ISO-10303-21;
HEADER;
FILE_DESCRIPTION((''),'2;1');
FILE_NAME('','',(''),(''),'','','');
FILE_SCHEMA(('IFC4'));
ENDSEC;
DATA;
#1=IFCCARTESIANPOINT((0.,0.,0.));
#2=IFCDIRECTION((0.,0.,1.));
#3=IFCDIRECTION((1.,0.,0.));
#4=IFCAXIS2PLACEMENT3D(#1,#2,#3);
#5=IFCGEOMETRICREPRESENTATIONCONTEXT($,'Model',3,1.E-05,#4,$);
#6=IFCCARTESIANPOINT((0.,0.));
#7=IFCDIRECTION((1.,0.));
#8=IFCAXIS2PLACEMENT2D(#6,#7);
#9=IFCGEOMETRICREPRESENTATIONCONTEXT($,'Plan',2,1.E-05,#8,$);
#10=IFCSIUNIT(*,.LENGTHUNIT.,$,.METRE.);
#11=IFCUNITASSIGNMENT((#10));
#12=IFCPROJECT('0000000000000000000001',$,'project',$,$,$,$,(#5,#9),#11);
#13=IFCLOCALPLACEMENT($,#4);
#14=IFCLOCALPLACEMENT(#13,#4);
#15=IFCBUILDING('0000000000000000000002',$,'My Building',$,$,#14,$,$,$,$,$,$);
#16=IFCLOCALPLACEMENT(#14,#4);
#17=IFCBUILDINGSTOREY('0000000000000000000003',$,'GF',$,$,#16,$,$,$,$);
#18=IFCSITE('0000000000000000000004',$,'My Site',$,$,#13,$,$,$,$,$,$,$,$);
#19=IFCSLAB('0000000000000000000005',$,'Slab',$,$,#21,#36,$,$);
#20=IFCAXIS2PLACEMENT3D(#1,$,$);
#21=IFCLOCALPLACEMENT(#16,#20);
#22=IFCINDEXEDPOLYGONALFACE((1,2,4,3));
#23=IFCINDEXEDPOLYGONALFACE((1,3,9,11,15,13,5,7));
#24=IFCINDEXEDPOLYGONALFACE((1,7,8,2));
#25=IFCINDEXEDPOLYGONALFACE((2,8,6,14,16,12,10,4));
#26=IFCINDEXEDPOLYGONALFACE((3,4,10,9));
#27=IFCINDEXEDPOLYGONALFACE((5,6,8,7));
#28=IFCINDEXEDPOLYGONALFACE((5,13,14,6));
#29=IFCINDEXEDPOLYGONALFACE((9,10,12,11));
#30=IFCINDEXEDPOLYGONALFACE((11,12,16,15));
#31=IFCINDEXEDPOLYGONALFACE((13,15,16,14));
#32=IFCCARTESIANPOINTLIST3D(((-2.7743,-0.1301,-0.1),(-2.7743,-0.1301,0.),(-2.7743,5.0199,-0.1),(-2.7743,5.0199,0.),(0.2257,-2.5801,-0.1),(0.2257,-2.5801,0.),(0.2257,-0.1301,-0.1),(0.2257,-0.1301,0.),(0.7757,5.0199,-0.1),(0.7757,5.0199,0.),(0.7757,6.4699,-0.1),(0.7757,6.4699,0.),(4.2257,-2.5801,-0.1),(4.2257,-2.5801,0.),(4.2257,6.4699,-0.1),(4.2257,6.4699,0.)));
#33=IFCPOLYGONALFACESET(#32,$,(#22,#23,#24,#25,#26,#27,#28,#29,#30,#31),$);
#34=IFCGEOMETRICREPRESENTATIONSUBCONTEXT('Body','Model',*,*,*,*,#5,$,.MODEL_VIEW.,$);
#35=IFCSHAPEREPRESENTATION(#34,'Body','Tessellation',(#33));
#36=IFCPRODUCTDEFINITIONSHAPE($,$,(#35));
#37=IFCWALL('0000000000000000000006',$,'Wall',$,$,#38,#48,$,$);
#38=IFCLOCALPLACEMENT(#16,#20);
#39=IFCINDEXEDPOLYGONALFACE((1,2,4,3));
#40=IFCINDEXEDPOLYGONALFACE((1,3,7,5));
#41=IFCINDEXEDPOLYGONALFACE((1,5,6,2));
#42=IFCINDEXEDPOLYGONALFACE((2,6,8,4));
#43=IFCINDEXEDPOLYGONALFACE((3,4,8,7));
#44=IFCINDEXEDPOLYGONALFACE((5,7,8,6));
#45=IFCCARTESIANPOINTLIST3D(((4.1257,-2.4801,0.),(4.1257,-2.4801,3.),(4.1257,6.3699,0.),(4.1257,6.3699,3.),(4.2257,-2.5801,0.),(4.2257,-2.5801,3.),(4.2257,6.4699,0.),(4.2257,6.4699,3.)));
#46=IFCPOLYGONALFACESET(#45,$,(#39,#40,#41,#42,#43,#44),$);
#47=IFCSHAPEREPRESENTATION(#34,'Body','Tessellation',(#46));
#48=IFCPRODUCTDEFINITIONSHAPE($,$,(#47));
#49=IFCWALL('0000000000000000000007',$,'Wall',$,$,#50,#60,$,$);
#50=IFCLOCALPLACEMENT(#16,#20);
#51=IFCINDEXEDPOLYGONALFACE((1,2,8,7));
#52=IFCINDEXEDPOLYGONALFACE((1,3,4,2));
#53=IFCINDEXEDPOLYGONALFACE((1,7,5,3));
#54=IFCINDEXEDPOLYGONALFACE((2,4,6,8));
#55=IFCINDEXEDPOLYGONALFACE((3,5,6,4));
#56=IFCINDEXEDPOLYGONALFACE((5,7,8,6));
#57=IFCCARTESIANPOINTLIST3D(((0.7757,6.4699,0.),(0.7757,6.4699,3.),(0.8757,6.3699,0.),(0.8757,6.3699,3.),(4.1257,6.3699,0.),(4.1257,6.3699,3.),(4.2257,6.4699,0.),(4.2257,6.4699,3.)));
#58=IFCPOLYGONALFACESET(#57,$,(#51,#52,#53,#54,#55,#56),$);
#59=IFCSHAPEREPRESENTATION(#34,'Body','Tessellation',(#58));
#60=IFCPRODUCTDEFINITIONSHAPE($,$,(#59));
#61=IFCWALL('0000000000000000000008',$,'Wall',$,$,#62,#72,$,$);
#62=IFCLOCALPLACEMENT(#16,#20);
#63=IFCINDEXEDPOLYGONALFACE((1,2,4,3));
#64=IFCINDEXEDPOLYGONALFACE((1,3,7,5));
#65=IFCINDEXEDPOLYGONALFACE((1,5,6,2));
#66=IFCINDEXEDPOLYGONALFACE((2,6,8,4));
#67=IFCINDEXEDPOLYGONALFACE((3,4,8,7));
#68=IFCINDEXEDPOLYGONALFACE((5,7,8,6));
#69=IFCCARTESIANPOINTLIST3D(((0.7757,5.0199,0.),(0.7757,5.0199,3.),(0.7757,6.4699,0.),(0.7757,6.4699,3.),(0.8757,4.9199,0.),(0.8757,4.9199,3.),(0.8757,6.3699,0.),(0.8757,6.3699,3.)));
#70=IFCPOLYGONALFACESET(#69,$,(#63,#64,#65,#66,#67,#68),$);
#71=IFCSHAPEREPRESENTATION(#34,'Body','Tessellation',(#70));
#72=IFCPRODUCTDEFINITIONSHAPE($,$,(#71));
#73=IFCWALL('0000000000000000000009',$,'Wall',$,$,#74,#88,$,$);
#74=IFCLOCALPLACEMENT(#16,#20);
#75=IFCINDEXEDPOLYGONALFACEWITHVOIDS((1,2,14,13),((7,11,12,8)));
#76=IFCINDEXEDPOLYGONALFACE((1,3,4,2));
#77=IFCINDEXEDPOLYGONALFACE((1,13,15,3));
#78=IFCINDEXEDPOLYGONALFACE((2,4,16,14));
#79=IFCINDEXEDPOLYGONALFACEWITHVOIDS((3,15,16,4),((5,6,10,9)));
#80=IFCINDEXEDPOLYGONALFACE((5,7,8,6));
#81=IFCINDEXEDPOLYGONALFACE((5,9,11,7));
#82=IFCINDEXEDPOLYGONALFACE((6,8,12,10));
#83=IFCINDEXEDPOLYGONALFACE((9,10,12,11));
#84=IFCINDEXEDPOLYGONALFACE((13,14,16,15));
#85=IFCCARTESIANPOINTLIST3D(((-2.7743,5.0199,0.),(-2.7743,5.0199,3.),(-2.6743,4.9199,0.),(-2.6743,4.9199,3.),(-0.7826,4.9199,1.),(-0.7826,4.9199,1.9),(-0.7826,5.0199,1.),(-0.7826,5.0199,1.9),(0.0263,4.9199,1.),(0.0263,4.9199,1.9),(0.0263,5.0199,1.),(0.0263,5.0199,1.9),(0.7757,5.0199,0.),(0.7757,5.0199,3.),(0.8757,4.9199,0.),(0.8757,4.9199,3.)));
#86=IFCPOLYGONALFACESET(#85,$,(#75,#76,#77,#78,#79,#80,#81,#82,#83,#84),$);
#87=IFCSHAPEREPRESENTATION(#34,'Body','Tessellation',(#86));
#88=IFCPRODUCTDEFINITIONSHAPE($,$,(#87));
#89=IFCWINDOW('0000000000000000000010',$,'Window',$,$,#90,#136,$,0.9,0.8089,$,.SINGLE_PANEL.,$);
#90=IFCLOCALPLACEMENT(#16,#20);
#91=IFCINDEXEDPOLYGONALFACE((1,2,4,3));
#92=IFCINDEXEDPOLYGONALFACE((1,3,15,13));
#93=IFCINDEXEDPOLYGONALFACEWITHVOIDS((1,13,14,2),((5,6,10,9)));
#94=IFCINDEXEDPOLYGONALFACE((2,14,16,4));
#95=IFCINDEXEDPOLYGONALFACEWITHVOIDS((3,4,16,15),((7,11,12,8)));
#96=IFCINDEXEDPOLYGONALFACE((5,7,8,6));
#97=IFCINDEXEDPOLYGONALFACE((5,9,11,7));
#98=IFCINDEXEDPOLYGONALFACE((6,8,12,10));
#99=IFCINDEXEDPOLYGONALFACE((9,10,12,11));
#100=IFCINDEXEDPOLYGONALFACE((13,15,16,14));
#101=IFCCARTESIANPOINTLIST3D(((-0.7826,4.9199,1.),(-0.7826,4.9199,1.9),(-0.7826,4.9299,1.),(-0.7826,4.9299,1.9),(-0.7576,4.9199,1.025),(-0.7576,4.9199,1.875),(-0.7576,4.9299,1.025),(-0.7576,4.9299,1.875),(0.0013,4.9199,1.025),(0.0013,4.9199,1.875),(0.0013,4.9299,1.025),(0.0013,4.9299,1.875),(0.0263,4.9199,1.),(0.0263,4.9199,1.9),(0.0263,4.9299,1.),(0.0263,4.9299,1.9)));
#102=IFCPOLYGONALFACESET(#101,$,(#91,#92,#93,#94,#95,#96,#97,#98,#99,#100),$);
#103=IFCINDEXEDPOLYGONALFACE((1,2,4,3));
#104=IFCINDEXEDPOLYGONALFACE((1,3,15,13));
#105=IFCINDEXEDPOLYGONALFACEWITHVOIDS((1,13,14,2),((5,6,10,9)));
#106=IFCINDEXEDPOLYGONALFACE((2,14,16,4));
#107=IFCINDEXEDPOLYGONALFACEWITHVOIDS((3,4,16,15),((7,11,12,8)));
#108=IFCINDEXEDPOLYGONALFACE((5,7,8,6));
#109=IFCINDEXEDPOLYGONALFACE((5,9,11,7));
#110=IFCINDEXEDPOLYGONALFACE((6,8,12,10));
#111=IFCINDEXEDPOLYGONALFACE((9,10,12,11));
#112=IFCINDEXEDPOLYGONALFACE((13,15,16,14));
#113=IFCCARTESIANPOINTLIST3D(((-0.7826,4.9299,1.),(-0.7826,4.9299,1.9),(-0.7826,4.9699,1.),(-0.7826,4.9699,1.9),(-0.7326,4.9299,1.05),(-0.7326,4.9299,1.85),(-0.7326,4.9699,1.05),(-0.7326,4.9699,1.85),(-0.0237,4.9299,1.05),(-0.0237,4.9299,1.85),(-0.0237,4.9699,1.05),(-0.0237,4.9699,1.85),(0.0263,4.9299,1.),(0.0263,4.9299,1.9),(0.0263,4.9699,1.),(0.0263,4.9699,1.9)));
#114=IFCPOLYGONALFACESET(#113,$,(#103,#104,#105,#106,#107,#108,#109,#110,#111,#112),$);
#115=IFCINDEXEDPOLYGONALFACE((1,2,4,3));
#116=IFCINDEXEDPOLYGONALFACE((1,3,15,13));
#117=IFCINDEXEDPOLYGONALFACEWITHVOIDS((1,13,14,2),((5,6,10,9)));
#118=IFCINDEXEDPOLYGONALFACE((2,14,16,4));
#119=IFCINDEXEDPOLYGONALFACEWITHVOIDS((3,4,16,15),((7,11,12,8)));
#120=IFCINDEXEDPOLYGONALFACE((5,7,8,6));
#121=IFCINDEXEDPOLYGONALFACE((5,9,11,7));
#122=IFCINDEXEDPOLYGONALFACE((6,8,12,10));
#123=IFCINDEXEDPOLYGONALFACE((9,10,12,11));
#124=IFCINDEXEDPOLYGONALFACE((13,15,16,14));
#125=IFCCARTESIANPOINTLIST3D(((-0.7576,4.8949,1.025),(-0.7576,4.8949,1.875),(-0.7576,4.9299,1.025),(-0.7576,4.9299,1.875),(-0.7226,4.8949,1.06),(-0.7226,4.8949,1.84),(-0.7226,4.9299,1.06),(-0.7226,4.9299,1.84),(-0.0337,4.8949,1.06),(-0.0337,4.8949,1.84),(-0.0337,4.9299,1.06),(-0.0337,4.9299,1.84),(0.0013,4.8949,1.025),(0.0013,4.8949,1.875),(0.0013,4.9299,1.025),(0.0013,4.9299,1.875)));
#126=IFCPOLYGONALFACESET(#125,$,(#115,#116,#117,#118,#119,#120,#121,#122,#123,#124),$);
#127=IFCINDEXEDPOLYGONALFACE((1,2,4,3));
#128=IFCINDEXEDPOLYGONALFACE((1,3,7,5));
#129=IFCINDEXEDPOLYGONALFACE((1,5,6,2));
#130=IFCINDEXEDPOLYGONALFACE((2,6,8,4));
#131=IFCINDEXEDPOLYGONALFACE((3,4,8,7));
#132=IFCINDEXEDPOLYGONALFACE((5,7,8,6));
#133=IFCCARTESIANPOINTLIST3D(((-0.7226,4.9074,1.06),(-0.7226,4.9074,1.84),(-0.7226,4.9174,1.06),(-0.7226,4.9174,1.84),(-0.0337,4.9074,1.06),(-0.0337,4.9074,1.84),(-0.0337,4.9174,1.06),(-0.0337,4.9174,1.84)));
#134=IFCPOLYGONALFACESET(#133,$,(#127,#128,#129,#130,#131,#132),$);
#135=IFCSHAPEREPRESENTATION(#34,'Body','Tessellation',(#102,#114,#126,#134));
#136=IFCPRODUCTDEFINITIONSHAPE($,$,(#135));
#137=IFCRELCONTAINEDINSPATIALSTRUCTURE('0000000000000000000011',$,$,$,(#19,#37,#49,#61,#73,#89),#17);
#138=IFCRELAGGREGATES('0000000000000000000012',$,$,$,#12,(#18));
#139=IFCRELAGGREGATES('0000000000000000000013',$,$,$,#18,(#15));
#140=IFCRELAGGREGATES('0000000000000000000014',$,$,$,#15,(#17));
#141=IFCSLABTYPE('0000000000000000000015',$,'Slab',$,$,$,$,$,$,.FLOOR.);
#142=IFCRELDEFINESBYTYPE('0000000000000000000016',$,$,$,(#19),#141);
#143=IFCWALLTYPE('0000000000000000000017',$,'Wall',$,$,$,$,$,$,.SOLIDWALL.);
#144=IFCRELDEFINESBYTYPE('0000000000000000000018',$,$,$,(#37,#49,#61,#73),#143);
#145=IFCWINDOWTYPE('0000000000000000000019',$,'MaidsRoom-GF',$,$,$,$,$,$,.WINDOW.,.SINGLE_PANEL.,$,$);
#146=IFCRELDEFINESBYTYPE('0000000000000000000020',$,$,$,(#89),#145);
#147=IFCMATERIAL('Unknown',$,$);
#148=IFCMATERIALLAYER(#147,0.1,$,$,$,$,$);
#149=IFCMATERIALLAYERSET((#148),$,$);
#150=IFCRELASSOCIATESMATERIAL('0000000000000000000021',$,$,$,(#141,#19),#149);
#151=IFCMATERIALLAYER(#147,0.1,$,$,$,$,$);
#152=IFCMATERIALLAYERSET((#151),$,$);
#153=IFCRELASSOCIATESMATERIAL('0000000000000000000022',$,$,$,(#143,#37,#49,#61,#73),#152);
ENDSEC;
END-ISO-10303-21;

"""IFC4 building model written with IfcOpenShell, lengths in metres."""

from ifc_helpers import new_model, entity, si_unit, frame, origin_with_axes, origin_2d_with_axis, place, context, subcontext, project, spatial, line, indexed_curve, outline, extrude, shape, source, transform, mapped, material, layer, layer_set, layer_usage, type_object, type_shapes, element, fill, save


model = new_model("IFC4")

# Units and contexts
model_context = context("Model", 3, precision=1e-05, world=origin_with_axes())
plan_context = context("Plan", 2, precision=1e-05, world=origin_2d_with_axis())
body_context_1 = subcontext(model_context, "Body", "Model", "MODEL_VIEW")
body_context_2 = subcontext(plan_context, "Body", "Plan", "PLAN_VIEW")
ifc_project = project(units=[si_unit("LENGTHUNIT", "METRE")], contexts=[model_context, plan_context])

# Site, building, storey
site_placement = place(None, origin_with_axes())
site = spatial("IfcSite", under=ifc_project, at=site_placement, Name="My Site")
building_placement = place(site_placement, origin_with_axes())
building = spatial("IfcBuilding", under=site, at=building_placement, Name="My Building")
storey_placement = place(building_placement, origin_with_axes())
storey = spatial("IfcBuildingStorey", under=building, at=storey_placement, Name="GF")

# Slab
ifc_material = material(Name="Unknown")
ifc_layer_1 = layer(ifc_material, 0.1)
ifc_layer_set_1 = layer_set([ifc_layer_1])
ifc_layer_usage_1 = layer_usage(ifc_layer_set_1, "AXIS3", "POSITIVE", -0.1)
slab_type = type_object("IfcSlabType", Name="Slab", PredefinedType="FLOOR", material=ifc_layer_set_1)
slab_placement = place(storey_placement, frame((4.2257, 6.4699, 0.0), z_axis=(0.0, 0.0, 1.0), x_axis=(1.0, 0.0, 0.0)))
element("IfcSlab", 1, at=slab_placement, inside=storey, type_object=slab_type, material=ifc_layer_usage_1, Name="Slab", context=body_context_1, shape_type="SweptSolid", body=[
    extrude(outline(indexed_curve([(0.0, 0.0), (-3.45, 0.0), (-3.45, -1.45), (-7.0, -1.45), (-7.0, -6.6), (-4.0, -6.6), (-4.0, -9.05), (0.0, -9.05), (0.0, 0.0)])), frame((0.0, 0.0, -0.1), z_axis=(0.0, 0.0, 1.0), x_axis=(1.0, 0.0, 0.0)), (0.0, 0.0, 1.0), 0.1),
])

# Shared definitions
ifc_layer_2 = layer(ifc_material, 0.1)
ifc_layer_set_2 = layer_set([ifc_layer_2])
wall_type = type_object("IfcWallType", Name="Wall", PredefinedType="SOLIDWALL", material=ifc_layer_set_2)

# Walls
ifc_layer_usage_2 = layer_usage(ifc_layer_set_2, "AXIS2", "POSITIVE", 0.0)
wall_1_placement = place(storey_placement, frame((4.2257, -2.5801, 0.0), z_axis=(0.0, 0.0, 1.0), x_axis=(0.0, 1.0, 0.0)))
element("IfcWall", 2, at=wall_1_placement, inside=storey, type_object=wall_type, material=ifc_layer_usage_2, Name="Wall", context=body_context_1, shape_type="SweptSolid", body=[
    extrude(outline(indexed_curve([(0.0, 0.0), (0.1, 0.1), (8.95, 0.1), (9.05, 0.0)], segments=[line(1, 2, 3, 4, 1)])), origin_with_axes(), (0.0, 0.0, 1.0), 3.0),
])
ifc_layer_usage_3 = layer_usage(ifc_layer_set_2, "AXIS2", "POSITIVE", 0.0)
wall_2_placement = place(storey_placement, frame((4.2257, 6.4699, 0.0), z_axis=(0.0, 0.0, 1.0), x_axis=(-1.0, 0.0, 0.0)))
element("IfcWall", 3, at=wall_2_placement, inside=storey, type_object=wall_type, material=ifc_layer_usage_3, Name="Wall", context=body_context_1, shape_type="SweptSolid", body=[
    extrude(outline(indexed_curve([(0.0, 0.0), (0.1, 0.1), (3.35, 0.1), (3.45, 0.0)], segments=[line(1, 2, 3, 4, 1)])), origin_with_axes(), (0.0, 0.0, 1.0), 3.0),
])
ifc_layer_usage_4 = layer_usage(ifc_layer_set_2, "AXIS2", "POSITIVE", 0.0)
wall_3_placement = place(storey_placement, frame((0.7757, 6.4699, 0.0), z_axis=(0.0, 0.0, 1.0), x_axis=(0.0, -1.0, 0.0)))
element("IfcWall", 4, at=wall_3_placement, inside=storey, type_object=wall_type, material=ifc_layer_usage_4, Name="Wall", context=body_context_1, shape_type="SweptSolid", body=[
    extrude(outline(indexed_curve([(0.0, 0.0), (0.1, 0.1), (1.55, 0.1), (1.45, 0.0)], segments=[line(1, 2, 3, 4, 1)])), origin_with_axes(), (0.0, 0.0, 1.0), 3.0),
])

# Wall, opening, window
ifc_layer_usage_5 = layer_usage(ifc_layer_set_2, "AXIS2", "POSITIVE", 0.0)
wall_4_placement = place(storey_placement, frame((0.7757, 5.0199, 0.0), z_axis=(0.0, 0.0, 1.0), x_axis=(-1.0, 0.0, 0.0)))
wall_4 = element("IfcWall", 5, at=wall_4_placement, inside=storey, type_object=wall_type, material=ifc_layer_usage_5, Name="Wall", context=body_context_1, shape_type="SweptSolid", body=[
    extrude(outline(indexed_curve([(0.0, 0.0), (-0.1, 0.1), (3.45, 0.1), (3.55, 0.0)], segments=[line(1, 2, 3, 4, 1)])), origin_with_axes(), (0.0, 0.0, 1.0), 3.0),
])
shared_shape_1 = source(origin_with_axes(), body_context_1, "Body", "SweptSolid", [
    extrude(outline(indexed_curve([(0.0, 0.0), (0.8089, 0.0), (0.8089, 0.9), (0.0, 0.9)], segments=[line(1, 2, 3, 4, 1)])), frame((0.0, -0.6, 0.0), z_axis=(0.0, -1.0, 0.0), x_axis=(1.0, 0.0, 0.0)), (0.0, 0.0, -1.0), 1.2),
])
opening_1_placement = place(wall_4_placement, frame((0.7494, 0.0, 1.0), z_axis=(0.0, 0.0, 1.0), x_axis=(1.0, 0.0, 0.0)))
opening_1 = element("IfcOpeningElement", 6, at=opening_1_placement, cuts=wall_4, PredefinedType="OPENING", context=body_context_1, shape_type="MappedRepresentation", body=[
    mapped(shared_shape_1, transform((0.0, 0.0, 0.0), x_axis=(1.0, 0.0, 0.0), y_axis=(0.0, 1.0, 0.0), z_axis=(0.0, 0.0, 1.0), scale=1.0)),
])
window_type_1 = type_object("IfcWindowType", Name="MaidsRoom-GF", PartitioningType="SINGLE_PANEL", PredefinedType="WINDOW")
shared_shape_2 = source(origin_with_axes(), body_context_1, "Body", "SweptSolid", [
    extrude(outline(indexed_curve([(0.0, 0.0), (0.8089, 0.0), (0.8089, 0.9), (0.0, 0.9)], segments=[line(1, 2, 3, 4, 1)]), holes=[indexed_curve([(0.025, 0.025), (0.7839, 0.025), (0.7839, 0.875), (0.025, 0.875)], segments=[line(1, 2, 3, 4, 1)])]), frame((0.0, 0.09, 0.0), z_axis=(0.0, -1.0, 0.0), x_axis=(1.0, 0.0, 0.0)), (0.0, 0.0, -1.0), 0.01),
    extrude(outline(indexed_curve([(0.0, 0.0), (0.8089, 0.0), (0.8089, 0.9), (0.0, 0.9)], segments=[line(1, 2, 3, 4, 1)]), holes=[indexed_curve([(0.05, 0.05), (0.7589, 0.05), (0.7589, 0.85), (0.05, 0.85)], segments=[line(1, 2, 3, 4, 1)])]), frame((0.0, 0.05, 0.0), z_axis=(0.0, -1.0, 0.0), x_axis=(1.0, 0.0, 0.0)), (0.0, 0.0, -1.0), 0.04),
    extrude(outline(indexed_curve([(0.0, 0.0), (0.7589, 0.0), (0.7589, 0.85), (0.0, 0.85)], segments=[line(1, 2, 3, 4, 1)]), holes=[indexed_curve([(0.035, 0.035), (0.7239, 0.035), (0.7239, 0.815), (0.035, 0.815)], segments=[line(1, 2, 3, 4, 1)])]), frame((0.025, 0.09, 0.025), z_axis=(0.0, -1.0, 0.0), x_axis=(1.0, 0.0, 0.0)), (0.0, 0.0, -1.0), 0.035),
    extrude(outline(indexed_curve([(0.035, 0.035), (0.7239, 0.035), (0.7239, 0.815), (0.035, 0.815)], segments=[line(1, 2, 3, 4, 1)])), frame((0.025, 0.1025, 0.025), z_axis=(0.0, -1.0, 0.0), x_axis=(1.0, 0.0, 0.0)), (0.0, 0.0, -1.0), 0.01),
])
shared_shape_3 = source(origin_with_axes(), body_context_2, "Body", "Curve2D", [
    entity("IfcIndexedPolyCurve", entity("IfcCartesianPointList2D", [[0.05, 0.05], [0.7589, 0.05]])),
    entity("IfcIndexedPolyCurve", entity("IfcCartesianPointList2D", [[0.0, 0.1], [0.025, 0.1], [0.025, 0.09], [0.05, 0.09], [0.05, 0.05], [0.0, 0.05]]), [entity("IfcLineIndex", [1, 2, 3, 4, 5, 6, 1])]),
    entity("IfcIndexedPolyCurve", entity("IfcCartesianPointList2D", [[0.8089, 0.1], [0.7839, 0.1], [0.7839, 0.09], [0.7589, 0.09], [0.7589, 0.05], [0.8089, 0.05]]), [entity("IfcLineIndex", [1, 2, 3, 4, 5, 6, 1])]),
    entity("IfcIndexedPolyCurve", entity("IfcCartesianPointList2D", [[0.025, 0.09], [0.06, 0.09], [0.06, 0.125], [0.025, 0.125]]), [entity("IfcLineIndex", [1, 2, 3, 4, 1])]),
    entity("IfcIndexedPolyCurve", entity("IfcCartesianPointList2D", [[0.7839, 0.09], [0.7489, 0.09], [0.7489, 0.125], [0.7839, 0.125]]), [entity("IfcLineIndex", [1, 2, 3, 4, 1])]),
    entity("IfcIndexedPolyCurve", entity("IfcCartesianPointList2D", [[0.06, 0.09], [0.7489, 0.09]])),
    entity("IfcIndexedPolyCurve", entity("IfcCartesianPointList2D", [[0.06, 0.125], [0.7489, 0.125]])),
    entity("IfcIndexedPolyCurve", entity("IfcCartesianPointList2D", [[0.06, 0.1075], [0.7489, 0.1075]])),
])
type_shapes(window_type_1, [shared_shape_2, shared_shape_3])
window_1_placement = place(opening_1_placement, origin_with_axes())
window_1 = element("IfcWindow", 7, at=window_1_placement, inside=storey, type_object=window_type_1, Name="Window", OverallHeight=0.9, OverallWidth=0.8089, PartitioningType="SINGLE_PANEL", shapes=[
    shape(body_context_1, "Body", "MappedRepresentation", [mapped(shared_shape_2, transform((0.0, 0.0, 0.0), x_axis=(1.0, 0.0, 0.0), y_axis=(0.0, 1.0, 0.0), z_axis=(0.0, 0.0, 1.0), scale=1.0))]),
    shape(body_context_2, "Body", "MappedRepresentation", [mapped(shared_shape_3, transform((0.0, 0.0, 0.0), x_axis=(1.0, 0.0, 0.0), y_axis=(0.0, 1.0, 0.0), z_axis=(0.0, 0.0, 1.0), scale=1.0))]),
])
fill(opening_1, window_1)

save(model, "model.ifc")
